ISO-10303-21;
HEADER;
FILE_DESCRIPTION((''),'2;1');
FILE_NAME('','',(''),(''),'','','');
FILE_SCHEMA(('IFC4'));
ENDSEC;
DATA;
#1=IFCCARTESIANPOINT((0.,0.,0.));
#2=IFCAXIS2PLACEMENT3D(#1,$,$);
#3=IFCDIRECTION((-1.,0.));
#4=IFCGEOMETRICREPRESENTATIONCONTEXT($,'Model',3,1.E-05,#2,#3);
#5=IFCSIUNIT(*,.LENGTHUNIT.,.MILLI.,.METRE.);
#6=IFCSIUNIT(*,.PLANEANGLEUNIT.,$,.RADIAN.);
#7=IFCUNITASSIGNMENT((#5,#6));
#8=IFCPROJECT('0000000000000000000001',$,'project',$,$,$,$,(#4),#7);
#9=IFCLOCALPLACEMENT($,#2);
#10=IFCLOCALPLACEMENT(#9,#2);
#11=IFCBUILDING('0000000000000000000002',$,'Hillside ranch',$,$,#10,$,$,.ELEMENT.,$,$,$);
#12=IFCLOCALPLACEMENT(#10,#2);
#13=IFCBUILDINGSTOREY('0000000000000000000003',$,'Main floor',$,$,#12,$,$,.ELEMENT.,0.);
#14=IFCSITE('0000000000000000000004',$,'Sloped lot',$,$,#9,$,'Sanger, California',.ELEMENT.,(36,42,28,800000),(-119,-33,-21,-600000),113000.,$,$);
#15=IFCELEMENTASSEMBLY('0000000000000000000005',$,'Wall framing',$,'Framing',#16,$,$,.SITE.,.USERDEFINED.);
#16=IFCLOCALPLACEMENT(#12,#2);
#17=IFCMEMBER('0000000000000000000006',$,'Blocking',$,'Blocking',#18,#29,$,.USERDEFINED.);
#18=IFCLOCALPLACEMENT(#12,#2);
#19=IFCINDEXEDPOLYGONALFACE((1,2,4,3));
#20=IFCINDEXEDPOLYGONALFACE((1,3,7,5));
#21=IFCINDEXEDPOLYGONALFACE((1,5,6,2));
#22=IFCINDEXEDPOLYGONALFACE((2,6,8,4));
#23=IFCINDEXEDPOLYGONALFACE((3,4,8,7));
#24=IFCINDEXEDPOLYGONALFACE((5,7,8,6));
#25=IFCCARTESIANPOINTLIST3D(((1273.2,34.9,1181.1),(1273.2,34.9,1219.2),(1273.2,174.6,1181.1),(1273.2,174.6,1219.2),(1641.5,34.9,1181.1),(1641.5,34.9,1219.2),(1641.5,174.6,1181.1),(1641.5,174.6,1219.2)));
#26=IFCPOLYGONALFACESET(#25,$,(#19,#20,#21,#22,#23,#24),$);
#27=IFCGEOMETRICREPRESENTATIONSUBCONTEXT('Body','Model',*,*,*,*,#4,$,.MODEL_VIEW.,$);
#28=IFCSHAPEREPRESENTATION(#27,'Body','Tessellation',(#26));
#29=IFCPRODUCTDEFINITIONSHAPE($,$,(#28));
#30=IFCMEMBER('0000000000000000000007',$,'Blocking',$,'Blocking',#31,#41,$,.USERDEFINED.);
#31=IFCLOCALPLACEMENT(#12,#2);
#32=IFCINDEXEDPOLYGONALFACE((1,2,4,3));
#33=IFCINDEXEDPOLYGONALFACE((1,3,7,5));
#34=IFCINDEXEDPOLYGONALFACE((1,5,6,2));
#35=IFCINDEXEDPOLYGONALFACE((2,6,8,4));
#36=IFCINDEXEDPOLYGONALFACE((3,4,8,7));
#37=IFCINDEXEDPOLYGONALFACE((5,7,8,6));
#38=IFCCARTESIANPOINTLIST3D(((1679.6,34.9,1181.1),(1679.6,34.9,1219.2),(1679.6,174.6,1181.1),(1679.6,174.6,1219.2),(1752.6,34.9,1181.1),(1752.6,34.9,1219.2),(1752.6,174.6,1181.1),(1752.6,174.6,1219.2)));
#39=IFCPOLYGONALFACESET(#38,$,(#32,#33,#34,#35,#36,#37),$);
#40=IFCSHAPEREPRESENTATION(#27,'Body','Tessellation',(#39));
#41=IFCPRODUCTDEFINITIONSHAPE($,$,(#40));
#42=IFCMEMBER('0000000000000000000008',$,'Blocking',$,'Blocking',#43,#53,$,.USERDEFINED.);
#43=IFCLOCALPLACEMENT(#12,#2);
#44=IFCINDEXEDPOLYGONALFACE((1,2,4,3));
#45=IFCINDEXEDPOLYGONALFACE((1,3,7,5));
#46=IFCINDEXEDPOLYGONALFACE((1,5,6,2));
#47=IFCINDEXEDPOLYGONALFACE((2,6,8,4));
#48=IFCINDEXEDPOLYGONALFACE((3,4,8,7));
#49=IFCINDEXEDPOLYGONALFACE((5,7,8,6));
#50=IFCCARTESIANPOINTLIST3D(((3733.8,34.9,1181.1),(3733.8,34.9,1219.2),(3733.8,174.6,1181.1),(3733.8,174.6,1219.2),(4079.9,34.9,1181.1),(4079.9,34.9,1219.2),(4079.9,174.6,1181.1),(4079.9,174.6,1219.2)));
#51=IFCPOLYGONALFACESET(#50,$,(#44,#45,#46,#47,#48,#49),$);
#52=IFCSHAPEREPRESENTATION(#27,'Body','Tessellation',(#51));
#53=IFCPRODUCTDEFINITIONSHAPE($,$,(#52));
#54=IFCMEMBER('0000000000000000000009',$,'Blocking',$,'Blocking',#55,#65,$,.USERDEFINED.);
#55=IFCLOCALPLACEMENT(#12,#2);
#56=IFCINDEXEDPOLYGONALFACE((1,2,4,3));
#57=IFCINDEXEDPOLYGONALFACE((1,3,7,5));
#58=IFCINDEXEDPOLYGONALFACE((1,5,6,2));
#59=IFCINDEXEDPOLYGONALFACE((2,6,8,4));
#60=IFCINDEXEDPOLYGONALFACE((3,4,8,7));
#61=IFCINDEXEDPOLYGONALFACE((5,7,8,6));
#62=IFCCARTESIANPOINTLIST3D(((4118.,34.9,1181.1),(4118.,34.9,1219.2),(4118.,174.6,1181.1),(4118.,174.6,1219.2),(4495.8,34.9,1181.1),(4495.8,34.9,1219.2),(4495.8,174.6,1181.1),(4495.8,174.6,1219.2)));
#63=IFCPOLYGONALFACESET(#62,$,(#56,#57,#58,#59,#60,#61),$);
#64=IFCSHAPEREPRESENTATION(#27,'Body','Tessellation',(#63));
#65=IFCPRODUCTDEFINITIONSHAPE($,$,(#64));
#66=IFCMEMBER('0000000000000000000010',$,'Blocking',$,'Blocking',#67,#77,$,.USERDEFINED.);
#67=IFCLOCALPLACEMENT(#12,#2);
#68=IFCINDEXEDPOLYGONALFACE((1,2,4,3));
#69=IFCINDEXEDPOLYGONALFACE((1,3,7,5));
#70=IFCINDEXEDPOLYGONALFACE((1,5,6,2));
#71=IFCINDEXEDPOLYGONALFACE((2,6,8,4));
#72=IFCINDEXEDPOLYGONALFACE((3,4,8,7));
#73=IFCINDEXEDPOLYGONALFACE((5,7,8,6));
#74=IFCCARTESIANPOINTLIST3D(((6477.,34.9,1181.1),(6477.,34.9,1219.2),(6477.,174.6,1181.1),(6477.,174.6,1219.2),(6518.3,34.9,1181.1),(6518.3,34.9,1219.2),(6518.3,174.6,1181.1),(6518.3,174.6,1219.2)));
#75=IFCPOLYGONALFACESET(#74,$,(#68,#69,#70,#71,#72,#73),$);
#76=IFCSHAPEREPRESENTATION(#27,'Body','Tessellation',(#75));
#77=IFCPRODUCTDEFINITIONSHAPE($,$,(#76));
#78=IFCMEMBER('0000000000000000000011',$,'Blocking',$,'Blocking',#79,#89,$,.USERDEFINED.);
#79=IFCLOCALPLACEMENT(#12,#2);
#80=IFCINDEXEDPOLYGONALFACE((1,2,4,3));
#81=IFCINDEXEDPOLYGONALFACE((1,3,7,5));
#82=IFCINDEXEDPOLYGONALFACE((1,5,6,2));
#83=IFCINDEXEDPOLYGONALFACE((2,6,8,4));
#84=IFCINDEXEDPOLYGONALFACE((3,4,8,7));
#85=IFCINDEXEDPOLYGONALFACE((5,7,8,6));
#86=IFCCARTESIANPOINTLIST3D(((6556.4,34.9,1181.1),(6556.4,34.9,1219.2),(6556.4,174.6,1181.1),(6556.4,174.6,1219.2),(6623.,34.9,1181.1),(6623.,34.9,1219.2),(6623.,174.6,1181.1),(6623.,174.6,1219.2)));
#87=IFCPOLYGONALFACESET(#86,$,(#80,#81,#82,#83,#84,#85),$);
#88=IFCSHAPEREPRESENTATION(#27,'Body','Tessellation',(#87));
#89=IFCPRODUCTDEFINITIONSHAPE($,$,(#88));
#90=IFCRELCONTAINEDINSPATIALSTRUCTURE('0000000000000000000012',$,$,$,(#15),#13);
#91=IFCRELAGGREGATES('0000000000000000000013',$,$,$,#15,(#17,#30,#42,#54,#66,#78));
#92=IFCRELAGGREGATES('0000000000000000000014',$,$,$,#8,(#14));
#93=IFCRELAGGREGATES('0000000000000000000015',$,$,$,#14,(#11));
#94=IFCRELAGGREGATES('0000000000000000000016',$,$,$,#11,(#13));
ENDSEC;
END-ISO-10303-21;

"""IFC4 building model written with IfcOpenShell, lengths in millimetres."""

from ifc_helpers import new_model, si_unit, direction, frame, origin, origin_with_axes, place, context, subcontext, project, spatial, polyline, outline, extrude, element, aggregate, save


model = new_model("IFC4")

# Units and contexts
model_context = context("Model", 3, precision=1e-05, world=origin(), true_north=direction((-1.0, 0.0)))
body_context = subcontext(model_context, "Body", "Model", "MODEL_VIEW")
ifc_project = project(units=[si_unit("LENGTHUNIT", "METRE", prefix="MILLI"), si_unit("PLANEANGLEUNIT", "RADIAN")], contexts=[model_context])

# Site, building, storey
site_placement = place(None, origin())
site = spatial("IfcSite", under=ifc_project, at=site_placement, Name="Sloped lot", LongName="Sanger, California", CompositionType="ELEMENT", RefLatitude=(36, 42, 28, 800000), RefLongitude=(-119, -33, -21, -600000), RefElevation=113000.0)
building_placement = place(site_placement, origin())
building = spatial("IfcBuilding", under=site, at=building_placement, Name="Hillside ranch", CompositionType="ELEMENT")
storey_placement = place(building_placement, origin())
storey = spatial("IfcBuildingStorey", under=building, at=storey_placement, Name="Main floor", CompositionType="ELEMENT", Elevation=0.0)

# Element assembly, members
assembly_placement = place(storey_placement, origin_with_axes())
assembly = element("IfcElementAssembly", 1, at=assembly_placement, inside=storey, Name="Wall framing", ObjectType="Framing", AssemblyPlace="SITE", PredefinedType="USERDEFINED")
member_1_placement = place(storey_placement, origin_with_axes())
member_1 = element("IfcMember", 2, at=member_1_placement, Name="Blocking", ObjectType="Blocking", PredefinedType="USERDEFINED", context=body_context, shape_type="SweptSolid", body=[
    extrude(outline(polyline([(0.0, 0.0), (368.3, 0.0), (368.3, 139.7), (0.0, 139.7), (0.0, 0.0)])), frame((1273.2, 34.9, 1181.1), z_axis=(0.0, 0.0, 1.0), x_axis=(1.0, 0.0, 0.0)), (0.0, 0.0, 1.0), 38.1),
])
member_2_placement = place(storey_placement, origin_with_axes())
member_2 = element("IfcMember", 3, at=member_2_placement, Name="Blocking", ObjectType="Blocking", PredefinedType="USERDEFINED", context=body_context, shape_type="SweptSolid", body=[
    extrude(outline(polyline([(0.0, 0.0), (73.0, 0.0), (73.0, 139.7), (0.0, 139.7), (0.0, 0.0)])), frame((1679.6, 34.9, 1181.1), z_axis=(0.0, 0.0, 1.0), x_axis=(1.0, 0.0, 0.0)), (0.0, 0.0, 1.0), 38.1),
])
member_3_placement = place(storey_placement, origin_with_axes())
member_3 = element("IfcMember", 4, at=member_3_placement, Name="Blocking", ObjectType="Blocking", PredefinedType="USERDEFINED", context=body_context, shape_type="SweptSolid", body=[
    extrude(outline(polyline([(0.0, 0.0), (346.1, 0.0), (346.1, 139.7), (0.0, 139.7), (0.0, 0.0)])), frame((3733.8, 34.9, 1181.1), z_axis=(0.0, 0.0, 1.0), x_axis=(1.0, 0.0, 0.0)), (0.0, 0.0, 1.0), 38.1),
])
member_4_placement = place(storey_placement, origin_with_axes())
member_4 = element("IfcMember", 5, at=member_4_placement, Name="Blocking", ObjectType="Blocking", PredefinedType="USERDEFINED", context=body_context, shape_type="SweptSolid", body=[
    extrude(outline(polyline([(0.0, 0.0), (377.8, 0.0), (377.8, 139.7), (0.0, 139.7), (0.0, 0.0)])), frame((4118.0, 34.9, 1181.1), z_axis=(0.0, 0.0, 1.0), x_axis=(1.0, 0.0, 0.0)), (0.0, 0.0, 1.0), 38.1),
])
member_5_placement = place(storey_placement, origin_with_axes())
member_5 = element("IfcMember", 6, at=member_5_placement, Name="Blocking", ObjectType="Blocking", PredefinedType="USERDEFINED", context=body_context, shape_type="SweptSolid", body=[
    extrude(outline(polyline([(0.0, 0.0), (41.3, 0.0), (41.3, 139.7), (0.0, 139.7), (0.0, 0.0)])), frame((6477.0, 34.9, 1181.1), z_axis=(0.0, 0.0, 1.0), x_axis=(1.0, 0.0, 0.0)), (0.0, 0.0, 1.0), 38.1),
])
member_6_placement = place(storey_placement, origin_with_axes())
member_6 = element("IfcMember", 7, at=member_6_placement, Name="Blocking", ObjectType="Blocking", PredefinedType="USERDEFINED", context=body_context, shape_type="SweptSolid", body=[
    extrude(outline(polyline([(0.0, 0.0), (66.7, 0.0), (66.7, 139.7), (0.0, 139.7), (0.0, 0.0)])), frame((6556.4, 34.9, 1181.1), z_axis=(0.0, 0.0, 1.0), x_axis=(1.0, 0.0, 0.0)), (0.0, 0.0, 1.0), 38.1),
])
aggregate(assembly, [member_1, member_2, member_3, member_4, member_5, member_6])

save(model, "model.ifc")
